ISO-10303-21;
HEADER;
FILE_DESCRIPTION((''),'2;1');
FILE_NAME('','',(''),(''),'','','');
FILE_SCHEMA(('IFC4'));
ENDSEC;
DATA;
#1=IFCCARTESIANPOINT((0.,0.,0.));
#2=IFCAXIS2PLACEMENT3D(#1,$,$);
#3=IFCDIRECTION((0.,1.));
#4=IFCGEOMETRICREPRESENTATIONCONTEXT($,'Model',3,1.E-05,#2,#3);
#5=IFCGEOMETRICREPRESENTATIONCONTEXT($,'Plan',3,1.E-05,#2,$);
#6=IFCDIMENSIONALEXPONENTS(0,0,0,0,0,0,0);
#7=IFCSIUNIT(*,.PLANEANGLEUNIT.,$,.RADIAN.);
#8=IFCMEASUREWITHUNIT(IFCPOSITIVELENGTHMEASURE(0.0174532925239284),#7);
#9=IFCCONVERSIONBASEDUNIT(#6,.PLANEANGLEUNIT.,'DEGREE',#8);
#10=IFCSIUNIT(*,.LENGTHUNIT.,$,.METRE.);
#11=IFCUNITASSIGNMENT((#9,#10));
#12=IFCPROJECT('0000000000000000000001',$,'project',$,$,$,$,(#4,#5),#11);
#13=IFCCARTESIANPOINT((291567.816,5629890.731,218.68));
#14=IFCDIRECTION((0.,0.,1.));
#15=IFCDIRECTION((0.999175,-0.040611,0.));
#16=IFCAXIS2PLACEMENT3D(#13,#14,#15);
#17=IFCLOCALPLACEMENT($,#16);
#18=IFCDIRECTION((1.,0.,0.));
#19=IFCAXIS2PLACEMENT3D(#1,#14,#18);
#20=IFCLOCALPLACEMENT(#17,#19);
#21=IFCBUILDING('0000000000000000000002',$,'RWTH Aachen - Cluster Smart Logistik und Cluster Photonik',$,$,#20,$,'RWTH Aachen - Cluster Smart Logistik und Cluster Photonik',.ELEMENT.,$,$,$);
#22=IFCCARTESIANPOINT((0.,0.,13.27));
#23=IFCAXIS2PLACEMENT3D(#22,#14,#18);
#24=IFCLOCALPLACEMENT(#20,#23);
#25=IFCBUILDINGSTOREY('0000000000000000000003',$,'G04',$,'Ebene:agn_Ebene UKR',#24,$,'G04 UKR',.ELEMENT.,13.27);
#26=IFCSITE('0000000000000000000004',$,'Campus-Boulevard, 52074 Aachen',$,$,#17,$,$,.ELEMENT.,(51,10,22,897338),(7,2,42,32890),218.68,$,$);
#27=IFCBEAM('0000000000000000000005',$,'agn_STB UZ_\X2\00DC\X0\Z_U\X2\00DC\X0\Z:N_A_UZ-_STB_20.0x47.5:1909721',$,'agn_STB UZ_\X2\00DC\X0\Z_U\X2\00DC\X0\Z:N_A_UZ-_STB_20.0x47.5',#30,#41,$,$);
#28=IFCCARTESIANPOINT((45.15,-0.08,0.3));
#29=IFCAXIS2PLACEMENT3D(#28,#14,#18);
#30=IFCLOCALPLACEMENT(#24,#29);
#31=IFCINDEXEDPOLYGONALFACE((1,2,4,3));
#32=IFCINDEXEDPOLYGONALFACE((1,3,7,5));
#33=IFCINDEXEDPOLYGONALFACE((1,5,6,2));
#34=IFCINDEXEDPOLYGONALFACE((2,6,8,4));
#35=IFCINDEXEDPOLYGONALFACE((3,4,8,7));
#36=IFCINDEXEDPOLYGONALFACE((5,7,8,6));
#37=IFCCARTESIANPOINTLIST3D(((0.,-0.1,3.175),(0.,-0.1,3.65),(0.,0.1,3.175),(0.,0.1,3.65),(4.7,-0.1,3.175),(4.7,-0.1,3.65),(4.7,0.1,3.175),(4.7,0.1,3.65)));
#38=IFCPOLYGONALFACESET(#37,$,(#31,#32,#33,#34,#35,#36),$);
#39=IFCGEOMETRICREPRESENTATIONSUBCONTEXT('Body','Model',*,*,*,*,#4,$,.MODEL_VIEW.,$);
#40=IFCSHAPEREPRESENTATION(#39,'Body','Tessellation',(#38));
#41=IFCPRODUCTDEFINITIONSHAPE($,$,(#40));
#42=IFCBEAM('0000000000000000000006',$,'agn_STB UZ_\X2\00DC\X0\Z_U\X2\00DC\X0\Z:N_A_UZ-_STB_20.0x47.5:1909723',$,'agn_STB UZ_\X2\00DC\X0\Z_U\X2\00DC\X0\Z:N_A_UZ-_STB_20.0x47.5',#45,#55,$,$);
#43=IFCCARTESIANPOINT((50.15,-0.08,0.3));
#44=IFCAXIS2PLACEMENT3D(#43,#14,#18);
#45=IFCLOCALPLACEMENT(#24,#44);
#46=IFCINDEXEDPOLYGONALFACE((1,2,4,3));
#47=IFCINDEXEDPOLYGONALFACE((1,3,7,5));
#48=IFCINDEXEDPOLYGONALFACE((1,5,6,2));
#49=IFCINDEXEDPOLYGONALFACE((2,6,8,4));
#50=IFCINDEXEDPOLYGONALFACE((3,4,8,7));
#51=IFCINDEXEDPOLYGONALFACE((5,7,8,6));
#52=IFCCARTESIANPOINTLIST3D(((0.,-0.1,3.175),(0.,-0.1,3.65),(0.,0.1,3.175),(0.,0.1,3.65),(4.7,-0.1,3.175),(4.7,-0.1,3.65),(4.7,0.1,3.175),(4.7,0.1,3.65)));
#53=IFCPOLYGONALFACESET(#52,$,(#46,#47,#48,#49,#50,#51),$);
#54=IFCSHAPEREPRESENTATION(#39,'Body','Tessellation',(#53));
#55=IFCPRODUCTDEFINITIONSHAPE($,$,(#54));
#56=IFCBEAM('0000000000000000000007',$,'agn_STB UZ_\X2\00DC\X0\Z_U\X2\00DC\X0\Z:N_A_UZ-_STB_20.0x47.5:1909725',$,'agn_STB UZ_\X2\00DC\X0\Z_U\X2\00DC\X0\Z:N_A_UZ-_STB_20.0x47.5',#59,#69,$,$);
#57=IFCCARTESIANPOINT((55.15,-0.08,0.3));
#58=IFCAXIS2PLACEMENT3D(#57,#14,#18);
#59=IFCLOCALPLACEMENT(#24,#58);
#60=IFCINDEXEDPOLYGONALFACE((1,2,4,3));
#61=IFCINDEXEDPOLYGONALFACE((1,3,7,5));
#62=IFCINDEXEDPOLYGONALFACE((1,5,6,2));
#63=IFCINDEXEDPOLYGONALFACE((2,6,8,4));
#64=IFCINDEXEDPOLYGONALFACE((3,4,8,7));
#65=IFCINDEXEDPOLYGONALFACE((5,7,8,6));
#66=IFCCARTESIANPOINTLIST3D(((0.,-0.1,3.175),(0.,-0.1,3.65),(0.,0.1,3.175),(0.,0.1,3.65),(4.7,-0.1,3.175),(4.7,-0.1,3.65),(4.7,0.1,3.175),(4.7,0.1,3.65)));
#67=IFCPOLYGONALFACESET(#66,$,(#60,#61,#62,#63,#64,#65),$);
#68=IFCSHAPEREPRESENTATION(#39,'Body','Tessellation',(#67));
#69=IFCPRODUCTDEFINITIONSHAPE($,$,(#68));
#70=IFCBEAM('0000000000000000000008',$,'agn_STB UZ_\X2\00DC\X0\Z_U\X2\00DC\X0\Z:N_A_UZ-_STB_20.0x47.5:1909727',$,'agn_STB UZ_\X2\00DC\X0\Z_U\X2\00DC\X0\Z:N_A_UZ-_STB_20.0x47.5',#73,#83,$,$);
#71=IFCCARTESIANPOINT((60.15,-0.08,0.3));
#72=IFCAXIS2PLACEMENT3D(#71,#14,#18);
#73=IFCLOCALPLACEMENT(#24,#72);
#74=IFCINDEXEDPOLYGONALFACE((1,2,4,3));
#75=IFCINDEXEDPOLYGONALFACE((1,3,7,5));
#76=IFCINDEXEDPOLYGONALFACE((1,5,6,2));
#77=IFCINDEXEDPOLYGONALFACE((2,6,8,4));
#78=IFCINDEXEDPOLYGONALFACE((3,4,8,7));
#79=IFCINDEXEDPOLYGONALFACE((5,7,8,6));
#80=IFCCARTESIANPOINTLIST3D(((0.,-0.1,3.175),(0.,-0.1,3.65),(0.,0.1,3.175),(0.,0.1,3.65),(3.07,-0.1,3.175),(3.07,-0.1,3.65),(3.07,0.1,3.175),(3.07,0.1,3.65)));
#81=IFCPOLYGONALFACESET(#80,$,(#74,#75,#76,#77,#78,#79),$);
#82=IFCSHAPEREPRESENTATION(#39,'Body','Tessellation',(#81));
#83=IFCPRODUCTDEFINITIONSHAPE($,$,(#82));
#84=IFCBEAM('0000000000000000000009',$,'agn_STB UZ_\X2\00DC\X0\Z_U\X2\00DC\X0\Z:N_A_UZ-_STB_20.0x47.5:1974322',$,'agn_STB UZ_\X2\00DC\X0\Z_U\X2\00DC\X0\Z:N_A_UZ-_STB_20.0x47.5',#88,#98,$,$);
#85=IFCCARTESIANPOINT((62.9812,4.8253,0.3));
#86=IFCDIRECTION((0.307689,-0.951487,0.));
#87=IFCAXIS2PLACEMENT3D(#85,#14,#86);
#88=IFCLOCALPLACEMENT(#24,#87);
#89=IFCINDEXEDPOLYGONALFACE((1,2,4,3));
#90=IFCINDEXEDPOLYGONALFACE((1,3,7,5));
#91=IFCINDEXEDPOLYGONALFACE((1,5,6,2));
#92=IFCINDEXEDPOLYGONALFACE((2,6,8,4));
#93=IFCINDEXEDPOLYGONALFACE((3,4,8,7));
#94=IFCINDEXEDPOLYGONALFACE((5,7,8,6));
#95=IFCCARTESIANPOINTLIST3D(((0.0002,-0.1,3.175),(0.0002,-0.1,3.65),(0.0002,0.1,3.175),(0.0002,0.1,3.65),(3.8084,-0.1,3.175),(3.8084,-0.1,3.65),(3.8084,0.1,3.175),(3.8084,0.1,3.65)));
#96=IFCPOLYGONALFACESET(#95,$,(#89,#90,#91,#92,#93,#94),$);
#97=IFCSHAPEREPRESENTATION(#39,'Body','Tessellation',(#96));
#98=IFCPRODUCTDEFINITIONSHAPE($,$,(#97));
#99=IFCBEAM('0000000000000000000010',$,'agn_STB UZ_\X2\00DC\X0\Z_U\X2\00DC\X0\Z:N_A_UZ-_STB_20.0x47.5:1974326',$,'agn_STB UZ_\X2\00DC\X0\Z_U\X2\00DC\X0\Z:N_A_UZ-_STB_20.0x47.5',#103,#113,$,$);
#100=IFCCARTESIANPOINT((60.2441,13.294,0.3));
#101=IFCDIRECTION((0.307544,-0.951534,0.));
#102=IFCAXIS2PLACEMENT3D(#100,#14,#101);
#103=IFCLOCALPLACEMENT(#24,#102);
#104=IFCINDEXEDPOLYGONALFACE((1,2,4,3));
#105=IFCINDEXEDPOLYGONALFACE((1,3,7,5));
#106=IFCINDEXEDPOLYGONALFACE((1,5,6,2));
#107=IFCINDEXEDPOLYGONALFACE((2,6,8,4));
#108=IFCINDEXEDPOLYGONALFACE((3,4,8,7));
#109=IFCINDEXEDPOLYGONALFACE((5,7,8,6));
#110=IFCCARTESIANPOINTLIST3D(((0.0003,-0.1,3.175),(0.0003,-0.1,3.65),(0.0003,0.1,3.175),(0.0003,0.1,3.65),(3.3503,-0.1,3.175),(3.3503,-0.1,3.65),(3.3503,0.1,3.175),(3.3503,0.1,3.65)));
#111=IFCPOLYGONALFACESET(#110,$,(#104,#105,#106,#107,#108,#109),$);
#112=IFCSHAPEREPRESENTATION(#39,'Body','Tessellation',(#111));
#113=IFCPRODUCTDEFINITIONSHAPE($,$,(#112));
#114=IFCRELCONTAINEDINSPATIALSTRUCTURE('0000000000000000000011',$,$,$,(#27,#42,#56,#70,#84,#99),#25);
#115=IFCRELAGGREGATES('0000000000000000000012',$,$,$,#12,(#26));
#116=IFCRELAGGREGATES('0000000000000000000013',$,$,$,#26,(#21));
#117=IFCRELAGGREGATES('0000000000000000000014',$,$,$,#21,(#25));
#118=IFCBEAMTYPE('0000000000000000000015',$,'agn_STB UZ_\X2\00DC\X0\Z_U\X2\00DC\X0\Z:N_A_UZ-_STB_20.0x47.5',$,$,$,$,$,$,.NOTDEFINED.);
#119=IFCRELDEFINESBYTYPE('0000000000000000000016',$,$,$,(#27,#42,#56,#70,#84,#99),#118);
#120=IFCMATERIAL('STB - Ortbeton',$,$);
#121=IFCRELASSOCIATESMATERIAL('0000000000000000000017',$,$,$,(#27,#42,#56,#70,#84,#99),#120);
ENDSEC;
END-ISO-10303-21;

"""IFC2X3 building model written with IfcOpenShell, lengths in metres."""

from ifc_helpers import new_model, entity, si_unit, converted_unit, direction, frame, frame_2d, origin, origin_with_axes, place, context, subcontext, project, spatial, rectangle, extrude, material, type_object, element, save


model = new_model("IFC2X3")

# Units and contexts
model_context = context("Model", 3, precision=1e-05, world=origin(), true_north=direction((0.0, 1.0)))
plan_context = context("Plan", 3, precision=1e-05, world=origin())
body_context = subcontext(model_context, "Body", "Model", "MODEL_VIEW")
ifc_project = project(units=[converted_unit("PLANEANGLEUNIT", "DEGREE", entity("IfcPositiveLengthMeasure", 0.0174532925239284), si_unit("PLANEANGLEUNIT", "RADIAN"), dimensions=[0, 0, 0, 0, 0, 0, 0]), si_unit("LENGTHUNIT", "METRE")], contexts=[model_context, plan_context])

# Site, building, storey
site_placement = place(None, frame((291567.816, 5629890.731, 218.68), z_axis=(0.0, 0.0, 1.0), x_axis=(0.999175, -0.040611, 0.0)))
site = spatial("IfcSite", under=ifc_project, at=site_placement, Name="Campus-Boulevard, 52074 Aachen", CompositionType="ELEMENT", RefLatitude=(51, 10, 22, 897338), RefLongitude=(7, 2, 42, 32890), RefElevation=218.68)
building_placement = place(site_placement, origin_with_axes())
building = spatial("IfcBuilding", under=site, at=building_placement, Name="RWTH Aachen - Cluster Smart Logistik und Cluster Photonik", LongName="RWTH Aachen - Cluster Smart Logistik und Cluster Photonik", CompositionType="ELEMENT")
storey_placement = place(building_placement, frame((0.0, 0.0, 13.27), z_axis=(0.0, 0.0, 1.0), x_axis=(1.0, 0.0, 0.0)))
storey = spatial("IfcBuildingStorey", under=building, at=storey_placement, Name="G04", ObjectType="Ebene:agn_Ebene UKR", LongName="G04 UKR", CompositionType="ELEMENT", Elevation=13.27)

# Beams
ifc_material_1 = material(Name="STB - Ortbeton")
beam_type_1 = type_object("IfcBeamType", Name="agn_STB UZ_ÜZ_UÜZ:N_A_UZ-_STB_20.0x47.5", PredefinedType="NOTDEFINED")
for number, where, z_axis, x_axis, name in (
    (1, (45.15, -0.08, 0.3), (0.0, 0.0, 1.0), (1.0, 0.0, 0.0), "agn_STB UZ_ÜZ_UÜZ:N_A_UZ-_STB_20.0x47.5:1909721"),
    (2, (50.15, -0.08, 0.3), (0.0, 0.0, 1.0), (1.0, 0.0, 0.0), "agn_STB UZ_ÜZ_UÜZ:N_A_UZ-_STB_20.0x47.5:1909723"),
    (3, (55.15, -0.08, 0.3), (0.0, 0.0, 1.0), (1.0, 0.0, 0.0), "agn_STB UZ_ÜZ_UÜZ:N_A_UZ-_STB_20.0x47.5:1909725"),
):
    element("IfcBeam", number, at=place(storey_placement, frame(where, z_axis=z_axis, x_axis=x_axis)), inside=storey, type_object=beam_type_1, material=ifc_material_1, Name=name, ObjectType="agn_STB UZ_ÜZ_UÜZ:N_A_UZ-_STB_20.0x47.5", context=body_context, shape_type="SweptSolid", body=[
        extrude(rectangle(XDim=0.475, YDim=0.2, at=frame_2d((0.0, 0.0), x_axis=(1.0, 0.0))), frame((0.0, 0.0, 3.4125), z_axis=(1.0, 0.0, 0.0), x_axis=(0.0, 0.0, -1.0)), (0.0, 0.0, 1.0), 4.7),
    ])
beam_1_placement = place(storey_placement, frame((60.15, -0.08, 0.3), z_axis=(0.0, 0.0, 1.0), x_axis=(1.0, 0.0, 0.0)))
element("IfcBeam", 4, at=beam_1_placement, inside=storey, type_object=beam_type_1, material=ifc_material_1, Name="agn_STB UZ_ÜZ_UÜZ:N_A_UZ-_STB_20.0x47.5:1909727", ObjectType="agn_STB UZ_ÜZ_UÜZ:N_A_UZ-_STB_20.0x47.5", context=body_context, shape_type="SweptSolid", body=[
    extrude(rectangle(XDim=0.475, YDim=0.2, at=frame_2d((0.0, 0.0), x_axis=(1.0, 0.0))), frame((0.0, 0.0, 3.4125), z_axis=(1.0, 0.0, 0.0), x_axis=(0.0, 0.0, -1.0)), (0.0, 0.0, 1.0), 3.07),
])
beam_2_placement = place(storey_placement, frame((62.9812, 4.8253, 0.3), z_axis=(0.0, 0.0, 1.0), x_axis=(0.307689, -0.951487, 0.0)))
element("IfcBeam", 5, at=beam_2_placement, inside=storey, type_object=beam_type_1, material=ifc_material_1, Name="agn_STB UZ_ÜZ_UÜZ:N_A_UZ-_STB_20.0x47.5:1974322", ObjectType="agn_STB UZ_ÜZ_UÜZ:N_A_UZ-_STB_20.0x47.5", context=body_context, shape_type="SweptSolid", body=[
    extrude(rectangle(XDim=0.475, YDim=0.2, at=frame_2d((0.0, 0.0), x_axis=(1.0, 0.0))), frame((0.0002, 0.0, 3.4125), z_axis=(1.0, 0.0, 0.0), x_axis=(0.0, 0.0, -1.0)), (0.0, 0.0, 1.0), 3.8082),
])
beam_3_placement = place(storey_placement, frame((60.2441, 13.294, 0.3), z_axis=(0.0, 0.0, 1.0), x_axis=(0.307544, -0.951534, 0.0)))
element("IfcBeam", 6, at=beam_3_placement, inside=storey, type_object=beam_type_1, material=ifc_material_1, Name="agn_STB UZ_ÜZ_UÜZ:N_A_UZ-_STB_20.0x47.5:1974326", ObjectType="agn_STB UZ_ÜZ_UÜZ:N_A_UZ-_STB_20.0x47.5", context=body_context, shape_type="SweptSolid", body=[
    extrude(rectangle(XDim=0.475, YDim=0.2, at=frame_2d((0.0, 0.0), x_axis=(1.0, 0.0))), frame((0.0003, 0.0, 3.4125), z_axis=(1.0, 0.0, 0.0), x_axis=(0.0, 0.0, -1.0)), (0.0, 0.0, 1.0), 3.35),
])

save(model, "model.ifc")
